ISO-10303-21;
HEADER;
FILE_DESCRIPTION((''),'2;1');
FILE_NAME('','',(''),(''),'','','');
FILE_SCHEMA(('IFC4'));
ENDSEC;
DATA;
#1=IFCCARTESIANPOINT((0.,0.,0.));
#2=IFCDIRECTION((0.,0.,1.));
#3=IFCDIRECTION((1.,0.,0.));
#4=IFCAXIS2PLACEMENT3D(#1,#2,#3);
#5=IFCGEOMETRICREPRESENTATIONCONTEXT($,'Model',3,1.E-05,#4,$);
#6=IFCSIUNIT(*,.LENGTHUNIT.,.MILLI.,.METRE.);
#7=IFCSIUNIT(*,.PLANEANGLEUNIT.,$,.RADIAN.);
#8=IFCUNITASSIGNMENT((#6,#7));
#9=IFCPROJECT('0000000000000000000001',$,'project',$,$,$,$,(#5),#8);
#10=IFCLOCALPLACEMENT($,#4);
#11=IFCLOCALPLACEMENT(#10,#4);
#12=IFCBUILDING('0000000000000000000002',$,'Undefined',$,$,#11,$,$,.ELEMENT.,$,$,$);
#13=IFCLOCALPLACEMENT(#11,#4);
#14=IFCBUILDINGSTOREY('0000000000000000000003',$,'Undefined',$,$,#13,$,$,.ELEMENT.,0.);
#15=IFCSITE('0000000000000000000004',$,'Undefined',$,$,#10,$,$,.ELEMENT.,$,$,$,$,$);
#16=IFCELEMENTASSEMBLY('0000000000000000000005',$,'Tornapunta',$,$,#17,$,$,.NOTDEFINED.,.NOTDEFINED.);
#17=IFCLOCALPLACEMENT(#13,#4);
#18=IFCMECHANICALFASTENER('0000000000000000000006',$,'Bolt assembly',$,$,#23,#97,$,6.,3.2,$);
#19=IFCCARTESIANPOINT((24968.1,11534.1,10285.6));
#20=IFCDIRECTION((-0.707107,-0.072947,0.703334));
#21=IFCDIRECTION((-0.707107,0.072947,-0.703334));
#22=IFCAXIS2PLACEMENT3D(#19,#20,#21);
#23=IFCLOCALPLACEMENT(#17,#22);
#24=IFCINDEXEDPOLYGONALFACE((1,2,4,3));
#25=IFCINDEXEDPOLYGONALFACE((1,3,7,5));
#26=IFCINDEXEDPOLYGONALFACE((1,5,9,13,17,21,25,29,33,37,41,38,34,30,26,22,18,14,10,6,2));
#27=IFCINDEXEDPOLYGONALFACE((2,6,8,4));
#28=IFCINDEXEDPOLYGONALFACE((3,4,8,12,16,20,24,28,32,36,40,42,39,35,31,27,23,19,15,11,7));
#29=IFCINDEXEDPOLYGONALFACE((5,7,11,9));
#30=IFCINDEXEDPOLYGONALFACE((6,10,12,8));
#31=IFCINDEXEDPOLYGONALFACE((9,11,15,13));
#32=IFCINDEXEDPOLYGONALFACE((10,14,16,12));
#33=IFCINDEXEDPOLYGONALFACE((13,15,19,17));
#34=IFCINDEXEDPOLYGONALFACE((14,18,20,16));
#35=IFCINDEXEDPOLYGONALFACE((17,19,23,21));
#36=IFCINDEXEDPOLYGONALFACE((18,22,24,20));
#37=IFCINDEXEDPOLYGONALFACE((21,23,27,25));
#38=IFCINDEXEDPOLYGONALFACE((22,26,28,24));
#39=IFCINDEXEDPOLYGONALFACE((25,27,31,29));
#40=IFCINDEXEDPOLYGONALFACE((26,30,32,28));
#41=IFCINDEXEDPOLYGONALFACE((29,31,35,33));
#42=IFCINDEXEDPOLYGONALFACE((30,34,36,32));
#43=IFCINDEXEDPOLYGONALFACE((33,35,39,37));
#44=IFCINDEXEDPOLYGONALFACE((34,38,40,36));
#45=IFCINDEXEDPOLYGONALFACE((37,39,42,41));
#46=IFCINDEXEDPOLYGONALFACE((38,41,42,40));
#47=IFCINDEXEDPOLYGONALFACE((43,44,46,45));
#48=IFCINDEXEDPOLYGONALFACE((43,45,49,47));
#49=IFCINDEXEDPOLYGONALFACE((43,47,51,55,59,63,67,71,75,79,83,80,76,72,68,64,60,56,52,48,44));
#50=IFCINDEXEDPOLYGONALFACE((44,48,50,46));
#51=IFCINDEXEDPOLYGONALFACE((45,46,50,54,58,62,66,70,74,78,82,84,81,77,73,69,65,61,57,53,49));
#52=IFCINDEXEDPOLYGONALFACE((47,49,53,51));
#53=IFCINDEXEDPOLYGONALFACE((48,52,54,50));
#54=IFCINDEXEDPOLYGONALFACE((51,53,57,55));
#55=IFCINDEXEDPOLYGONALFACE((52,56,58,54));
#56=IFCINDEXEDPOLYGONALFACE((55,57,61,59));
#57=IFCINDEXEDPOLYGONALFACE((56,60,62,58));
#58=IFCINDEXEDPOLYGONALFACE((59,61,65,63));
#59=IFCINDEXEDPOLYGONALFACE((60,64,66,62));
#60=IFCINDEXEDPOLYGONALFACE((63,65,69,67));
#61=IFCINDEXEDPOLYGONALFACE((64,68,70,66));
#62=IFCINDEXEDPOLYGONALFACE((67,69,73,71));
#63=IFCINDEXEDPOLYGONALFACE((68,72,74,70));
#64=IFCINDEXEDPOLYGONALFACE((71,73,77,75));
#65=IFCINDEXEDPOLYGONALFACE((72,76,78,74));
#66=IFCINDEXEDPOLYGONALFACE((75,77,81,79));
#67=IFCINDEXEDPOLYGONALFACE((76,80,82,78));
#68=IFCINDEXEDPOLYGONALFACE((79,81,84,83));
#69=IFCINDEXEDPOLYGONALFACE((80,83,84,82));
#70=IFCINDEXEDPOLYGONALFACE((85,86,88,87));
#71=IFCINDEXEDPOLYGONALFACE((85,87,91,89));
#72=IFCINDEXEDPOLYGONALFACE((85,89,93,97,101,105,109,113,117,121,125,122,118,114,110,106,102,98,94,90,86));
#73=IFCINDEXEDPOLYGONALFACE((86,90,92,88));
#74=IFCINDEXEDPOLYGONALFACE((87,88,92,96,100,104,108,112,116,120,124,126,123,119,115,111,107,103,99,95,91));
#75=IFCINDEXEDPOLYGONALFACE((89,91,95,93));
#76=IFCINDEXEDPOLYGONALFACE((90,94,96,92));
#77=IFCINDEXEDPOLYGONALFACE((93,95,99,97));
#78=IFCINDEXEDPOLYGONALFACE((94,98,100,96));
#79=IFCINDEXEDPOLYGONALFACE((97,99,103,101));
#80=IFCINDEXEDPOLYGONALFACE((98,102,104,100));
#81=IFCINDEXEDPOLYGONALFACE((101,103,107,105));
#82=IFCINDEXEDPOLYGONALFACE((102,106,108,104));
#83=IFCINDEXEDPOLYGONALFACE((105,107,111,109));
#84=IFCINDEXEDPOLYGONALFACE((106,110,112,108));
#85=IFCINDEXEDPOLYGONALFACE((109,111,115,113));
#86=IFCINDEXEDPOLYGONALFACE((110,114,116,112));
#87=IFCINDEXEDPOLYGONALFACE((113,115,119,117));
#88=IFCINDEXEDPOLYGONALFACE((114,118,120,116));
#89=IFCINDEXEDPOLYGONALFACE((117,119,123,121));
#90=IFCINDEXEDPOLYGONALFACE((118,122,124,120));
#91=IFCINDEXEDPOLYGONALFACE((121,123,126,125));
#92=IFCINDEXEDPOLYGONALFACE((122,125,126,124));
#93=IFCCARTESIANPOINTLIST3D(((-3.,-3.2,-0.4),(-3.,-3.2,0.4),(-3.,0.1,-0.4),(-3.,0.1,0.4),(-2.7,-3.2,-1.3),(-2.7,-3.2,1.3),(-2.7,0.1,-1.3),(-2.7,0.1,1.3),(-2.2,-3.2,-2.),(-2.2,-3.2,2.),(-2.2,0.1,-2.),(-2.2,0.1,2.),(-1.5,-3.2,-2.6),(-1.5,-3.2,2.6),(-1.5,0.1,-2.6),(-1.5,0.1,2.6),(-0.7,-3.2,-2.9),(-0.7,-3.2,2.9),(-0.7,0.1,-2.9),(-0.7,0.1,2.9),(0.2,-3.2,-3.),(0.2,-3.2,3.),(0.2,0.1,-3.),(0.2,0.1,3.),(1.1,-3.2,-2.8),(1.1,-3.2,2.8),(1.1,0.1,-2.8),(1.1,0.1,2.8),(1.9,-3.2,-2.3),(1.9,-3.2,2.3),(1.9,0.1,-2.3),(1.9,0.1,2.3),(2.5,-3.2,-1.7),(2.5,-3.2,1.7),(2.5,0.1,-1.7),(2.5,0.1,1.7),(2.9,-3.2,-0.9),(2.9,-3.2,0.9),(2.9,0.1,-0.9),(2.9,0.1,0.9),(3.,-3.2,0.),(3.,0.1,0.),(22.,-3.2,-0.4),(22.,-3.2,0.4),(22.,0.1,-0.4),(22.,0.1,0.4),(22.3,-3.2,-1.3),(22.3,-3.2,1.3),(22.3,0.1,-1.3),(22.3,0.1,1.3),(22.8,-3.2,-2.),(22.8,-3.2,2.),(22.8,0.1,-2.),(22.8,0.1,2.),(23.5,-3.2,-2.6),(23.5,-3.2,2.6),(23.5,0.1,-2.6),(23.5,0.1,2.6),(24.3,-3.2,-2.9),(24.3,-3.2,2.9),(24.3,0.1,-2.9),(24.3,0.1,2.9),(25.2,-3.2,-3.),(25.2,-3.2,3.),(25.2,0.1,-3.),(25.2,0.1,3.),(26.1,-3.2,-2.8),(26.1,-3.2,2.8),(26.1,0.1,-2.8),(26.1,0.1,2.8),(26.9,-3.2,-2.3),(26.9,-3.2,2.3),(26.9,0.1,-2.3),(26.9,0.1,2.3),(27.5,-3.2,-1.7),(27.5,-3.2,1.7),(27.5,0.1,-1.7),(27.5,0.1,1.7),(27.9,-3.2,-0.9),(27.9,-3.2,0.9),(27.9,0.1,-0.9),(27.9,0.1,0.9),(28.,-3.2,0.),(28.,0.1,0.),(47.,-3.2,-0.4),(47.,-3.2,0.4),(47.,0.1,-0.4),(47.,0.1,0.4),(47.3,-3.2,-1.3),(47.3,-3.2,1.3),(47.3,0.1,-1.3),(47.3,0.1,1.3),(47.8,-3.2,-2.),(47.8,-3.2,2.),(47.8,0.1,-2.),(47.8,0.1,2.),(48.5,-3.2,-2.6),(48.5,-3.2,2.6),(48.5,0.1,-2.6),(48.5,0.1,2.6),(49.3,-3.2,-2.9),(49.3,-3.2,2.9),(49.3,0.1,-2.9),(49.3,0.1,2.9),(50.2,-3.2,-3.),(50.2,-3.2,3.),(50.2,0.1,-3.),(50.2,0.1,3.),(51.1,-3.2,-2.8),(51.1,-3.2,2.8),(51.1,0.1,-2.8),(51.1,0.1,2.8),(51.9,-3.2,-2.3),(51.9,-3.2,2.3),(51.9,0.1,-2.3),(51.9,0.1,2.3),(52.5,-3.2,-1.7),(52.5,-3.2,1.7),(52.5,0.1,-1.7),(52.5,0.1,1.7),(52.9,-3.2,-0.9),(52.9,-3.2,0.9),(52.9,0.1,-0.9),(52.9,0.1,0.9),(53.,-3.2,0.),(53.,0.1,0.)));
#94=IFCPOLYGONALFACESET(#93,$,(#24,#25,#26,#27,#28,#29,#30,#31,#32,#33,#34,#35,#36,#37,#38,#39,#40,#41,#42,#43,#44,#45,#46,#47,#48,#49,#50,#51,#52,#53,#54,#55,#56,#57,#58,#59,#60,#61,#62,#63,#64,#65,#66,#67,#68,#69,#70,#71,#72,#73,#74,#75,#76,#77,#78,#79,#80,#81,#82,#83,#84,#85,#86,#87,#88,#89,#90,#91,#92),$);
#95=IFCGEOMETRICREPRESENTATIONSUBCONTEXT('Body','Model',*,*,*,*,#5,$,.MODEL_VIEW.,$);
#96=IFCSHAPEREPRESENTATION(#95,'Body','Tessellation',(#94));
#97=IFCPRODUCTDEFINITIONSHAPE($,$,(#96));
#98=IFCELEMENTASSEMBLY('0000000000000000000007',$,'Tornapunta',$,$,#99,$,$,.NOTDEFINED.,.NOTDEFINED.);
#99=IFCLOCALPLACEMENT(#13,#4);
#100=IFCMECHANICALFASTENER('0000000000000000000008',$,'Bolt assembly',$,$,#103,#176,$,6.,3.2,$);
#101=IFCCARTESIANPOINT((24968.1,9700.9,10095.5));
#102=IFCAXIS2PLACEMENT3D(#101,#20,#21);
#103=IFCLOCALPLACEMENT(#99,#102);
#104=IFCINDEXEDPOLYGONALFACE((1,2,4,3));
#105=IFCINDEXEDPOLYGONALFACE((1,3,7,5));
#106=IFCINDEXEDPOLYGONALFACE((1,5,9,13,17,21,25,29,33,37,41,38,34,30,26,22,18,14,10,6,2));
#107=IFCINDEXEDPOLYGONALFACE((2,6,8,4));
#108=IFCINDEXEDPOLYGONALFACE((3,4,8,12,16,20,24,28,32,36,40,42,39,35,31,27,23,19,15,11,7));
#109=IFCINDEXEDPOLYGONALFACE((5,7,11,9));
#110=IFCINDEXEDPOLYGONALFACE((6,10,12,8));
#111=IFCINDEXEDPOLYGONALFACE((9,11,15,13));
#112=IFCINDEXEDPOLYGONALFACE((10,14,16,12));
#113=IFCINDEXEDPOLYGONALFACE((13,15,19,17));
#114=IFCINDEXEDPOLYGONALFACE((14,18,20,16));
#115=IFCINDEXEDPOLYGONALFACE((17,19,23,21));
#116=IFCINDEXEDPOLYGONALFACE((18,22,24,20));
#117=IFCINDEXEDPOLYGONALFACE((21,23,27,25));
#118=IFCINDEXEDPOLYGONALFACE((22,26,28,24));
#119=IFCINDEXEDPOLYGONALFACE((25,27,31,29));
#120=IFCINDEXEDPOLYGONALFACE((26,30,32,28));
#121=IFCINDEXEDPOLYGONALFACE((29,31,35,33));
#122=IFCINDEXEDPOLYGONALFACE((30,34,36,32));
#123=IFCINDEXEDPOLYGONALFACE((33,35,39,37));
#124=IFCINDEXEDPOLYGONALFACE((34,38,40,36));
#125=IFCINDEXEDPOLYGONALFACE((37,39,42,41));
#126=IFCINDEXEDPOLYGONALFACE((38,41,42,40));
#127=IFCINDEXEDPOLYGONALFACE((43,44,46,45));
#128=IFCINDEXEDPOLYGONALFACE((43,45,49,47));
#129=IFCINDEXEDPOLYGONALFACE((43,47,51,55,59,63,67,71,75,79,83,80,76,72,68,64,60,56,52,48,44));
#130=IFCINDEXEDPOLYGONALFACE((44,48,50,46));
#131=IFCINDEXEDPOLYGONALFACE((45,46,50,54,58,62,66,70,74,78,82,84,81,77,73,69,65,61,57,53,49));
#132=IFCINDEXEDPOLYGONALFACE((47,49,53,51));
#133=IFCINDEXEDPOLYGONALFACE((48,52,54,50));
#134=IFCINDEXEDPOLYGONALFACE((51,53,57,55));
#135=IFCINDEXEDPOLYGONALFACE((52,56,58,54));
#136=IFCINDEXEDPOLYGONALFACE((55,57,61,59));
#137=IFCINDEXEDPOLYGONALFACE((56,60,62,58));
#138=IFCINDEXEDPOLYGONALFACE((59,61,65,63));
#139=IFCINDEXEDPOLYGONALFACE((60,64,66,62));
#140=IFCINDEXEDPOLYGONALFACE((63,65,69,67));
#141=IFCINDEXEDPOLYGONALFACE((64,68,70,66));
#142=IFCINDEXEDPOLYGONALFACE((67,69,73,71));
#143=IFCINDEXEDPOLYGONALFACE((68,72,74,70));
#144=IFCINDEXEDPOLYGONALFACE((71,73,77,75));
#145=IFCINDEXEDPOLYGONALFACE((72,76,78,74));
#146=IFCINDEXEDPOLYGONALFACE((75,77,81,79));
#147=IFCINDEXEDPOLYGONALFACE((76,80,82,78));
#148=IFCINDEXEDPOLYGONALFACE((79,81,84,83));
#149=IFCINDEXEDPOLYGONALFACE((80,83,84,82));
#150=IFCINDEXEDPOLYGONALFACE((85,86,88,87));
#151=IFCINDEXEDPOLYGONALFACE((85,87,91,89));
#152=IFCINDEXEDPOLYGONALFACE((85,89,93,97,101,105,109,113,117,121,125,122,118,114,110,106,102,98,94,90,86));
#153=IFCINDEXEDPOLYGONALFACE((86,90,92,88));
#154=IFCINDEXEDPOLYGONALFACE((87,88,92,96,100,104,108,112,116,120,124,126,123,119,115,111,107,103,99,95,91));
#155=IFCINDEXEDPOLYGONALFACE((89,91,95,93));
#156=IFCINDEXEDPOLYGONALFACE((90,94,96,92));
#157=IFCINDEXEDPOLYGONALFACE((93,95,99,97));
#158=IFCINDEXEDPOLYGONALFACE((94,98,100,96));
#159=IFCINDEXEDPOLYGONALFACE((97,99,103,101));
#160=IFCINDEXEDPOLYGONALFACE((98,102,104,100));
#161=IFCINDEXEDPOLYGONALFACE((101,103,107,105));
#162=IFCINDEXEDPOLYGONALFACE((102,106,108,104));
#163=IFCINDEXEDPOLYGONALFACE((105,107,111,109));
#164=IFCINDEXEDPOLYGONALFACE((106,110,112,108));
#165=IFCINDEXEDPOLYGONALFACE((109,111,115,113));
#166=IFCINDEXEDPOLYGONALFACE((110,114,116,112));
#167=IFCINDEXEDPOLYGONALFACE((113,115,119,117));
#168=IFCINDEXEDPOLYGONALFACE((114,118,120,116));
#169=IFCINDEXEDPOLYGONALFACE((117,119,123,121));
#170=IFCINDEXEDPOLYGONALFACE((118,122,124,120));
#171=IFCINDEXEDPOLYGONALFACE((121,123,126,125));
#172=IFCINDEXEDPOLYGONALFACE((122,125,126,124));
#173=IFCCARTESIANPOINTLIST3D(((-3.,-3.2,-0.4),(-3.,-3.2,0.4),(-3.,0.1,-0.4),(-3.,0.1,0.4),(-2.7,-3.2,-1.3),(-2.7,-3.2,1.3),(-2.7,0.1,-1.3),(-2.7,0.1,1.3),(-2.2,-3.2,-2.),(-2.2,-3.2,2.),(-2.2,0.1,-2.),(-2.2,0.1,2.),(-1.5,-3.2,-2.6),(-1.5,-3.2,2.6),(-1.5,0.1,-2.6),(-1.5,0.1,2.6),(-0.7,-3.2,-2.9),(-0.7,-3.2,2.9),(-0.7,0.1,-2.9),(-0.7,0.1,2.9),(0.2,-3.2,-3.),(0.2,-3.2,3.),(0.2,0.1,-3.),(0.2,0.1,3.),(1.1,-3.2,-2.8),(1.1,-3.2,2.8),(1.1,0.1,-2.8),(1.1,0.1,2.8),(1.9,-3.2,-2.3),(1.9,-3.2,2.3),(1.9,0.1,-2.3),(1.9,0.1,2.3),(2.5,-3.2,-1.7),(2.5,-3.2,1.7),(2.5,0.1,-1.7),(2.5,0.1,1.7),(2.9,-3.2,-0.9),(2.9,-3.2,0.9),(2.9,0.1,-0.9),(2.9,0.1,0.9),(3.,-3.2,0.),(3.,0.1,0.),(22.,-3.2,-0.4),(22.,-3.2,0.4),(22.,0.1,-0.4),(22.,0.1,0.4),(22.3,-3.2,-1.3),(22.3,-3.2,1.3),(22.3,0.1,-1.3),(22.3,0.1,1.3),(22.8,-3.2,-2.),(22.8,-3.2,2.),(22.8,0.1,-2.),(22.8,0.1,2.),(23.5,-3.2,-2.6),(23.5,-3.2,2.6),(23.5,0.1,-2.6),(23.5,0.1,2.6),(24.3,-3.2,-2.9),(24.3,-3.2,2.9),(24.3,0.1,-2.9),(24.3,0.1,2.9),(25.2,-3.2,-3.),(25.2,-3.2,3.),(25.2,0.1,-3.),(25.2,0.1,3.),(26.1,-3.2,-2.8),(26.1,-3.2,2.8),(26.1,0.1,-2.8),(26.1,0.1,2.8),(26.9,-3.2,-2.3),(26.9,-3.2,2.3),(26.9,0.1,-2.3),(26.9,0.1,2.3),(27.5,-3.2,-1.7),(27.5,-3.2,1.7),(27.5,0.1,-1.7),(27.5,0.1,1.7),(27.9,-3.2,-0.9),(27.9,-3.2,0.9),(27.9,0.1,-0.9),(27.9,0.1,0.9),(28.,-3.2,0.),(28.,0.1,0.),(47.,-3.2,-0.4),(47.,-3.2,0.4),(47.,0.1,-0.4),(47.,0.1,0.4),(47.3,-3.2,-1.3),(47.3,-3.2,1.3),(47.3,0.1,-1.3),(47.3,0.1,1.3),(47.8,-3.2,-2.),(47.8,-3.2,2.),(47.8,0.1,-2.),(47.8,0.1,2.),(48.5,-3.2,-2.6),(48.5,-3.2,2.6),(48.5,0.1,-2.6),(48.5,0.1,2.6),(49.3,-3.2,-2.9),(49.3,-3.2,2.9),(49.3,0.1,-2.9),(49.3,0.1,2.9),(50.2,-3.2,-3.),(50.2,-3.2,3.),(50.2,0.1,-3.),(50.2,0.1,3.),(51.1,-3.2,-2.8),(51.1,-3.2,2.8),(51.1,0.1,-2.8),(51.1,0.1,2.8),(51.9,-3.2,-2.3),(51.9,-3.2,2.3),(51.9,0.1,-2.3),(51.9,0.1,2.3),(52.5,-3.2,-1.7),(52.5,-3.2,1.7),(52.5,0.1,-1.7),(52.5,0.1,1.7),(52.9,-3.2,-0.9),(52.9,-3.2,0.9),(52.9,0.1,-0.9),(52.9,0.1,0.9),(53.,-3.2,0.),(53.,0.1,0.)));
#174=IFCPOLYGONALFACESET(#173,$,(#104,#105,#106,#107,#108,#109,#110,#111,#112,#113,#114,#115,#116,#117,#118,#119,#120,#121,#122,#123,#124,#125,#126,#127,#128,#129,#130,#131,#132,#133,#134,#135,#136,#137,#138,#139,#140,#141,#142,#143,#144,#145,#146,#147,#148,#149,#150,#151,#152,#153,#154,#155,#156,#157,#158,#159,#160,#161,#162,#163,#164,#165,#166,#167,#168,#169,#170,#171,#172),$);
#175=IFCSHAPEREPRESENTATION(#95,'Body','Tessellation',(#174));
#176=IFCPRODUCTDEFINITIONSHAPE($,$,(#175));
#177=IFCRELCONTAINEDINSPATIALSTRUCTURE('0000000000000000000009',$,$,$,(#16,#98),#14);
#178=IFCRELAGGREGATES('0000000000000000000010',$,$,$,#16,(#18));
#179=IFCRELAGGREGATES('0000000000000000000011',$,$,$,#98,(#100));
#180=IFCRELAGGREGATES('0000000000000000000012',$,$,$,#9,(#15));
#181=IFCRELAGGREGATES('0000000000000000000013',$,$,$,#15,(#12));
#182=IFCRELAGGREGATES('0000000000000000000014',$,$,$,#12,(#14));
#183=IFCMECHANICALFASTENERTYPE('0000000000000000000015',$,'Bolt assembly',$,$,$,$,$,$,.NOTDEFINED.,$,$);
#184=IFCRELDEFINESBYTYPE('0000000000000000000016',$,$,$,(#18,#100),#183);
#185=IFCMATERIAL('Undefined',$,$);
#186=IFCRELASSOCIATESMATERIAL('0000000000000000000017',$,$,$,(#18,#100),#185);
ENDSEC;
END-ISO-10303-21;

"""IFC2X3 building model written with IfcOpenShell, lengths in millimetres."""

from ifc_helpers import new_model, si_unit, frame, origin_with_axes, origin_2d_with_axis, place, context, subcontext, project, spatial, circle, extrude, source, transform, mapped, material, type_object, element, aggregate, save


model = new_model("IFC2X3")

# Units and contexts
model_context = context("Model", 3, precision=1e-05, world=origin_with_axes())
body_context = subcontext(model_context, "Body", "Model", "MODEL_VIEW")
ifc_project = project(units=[si_unit("LENGTHUNIT", "METRE", prefix="MILLI"), si_unit("PLANEANGLEUNIT", "RADIAN")], contexts=[model_context])

# Site, building, storey
site_placement = place(None, origin_with_axes())
site = spatial("IfcSite", under=ifc_project, at=site_placement, Name="Undefined", CompositionType="ELEMENT")
building_placement = place(site_placement, origin_with_axes())
building = spatial("IfcBuilding", under=site, at=building_placement, Name="Undefined", CompositionType="ELEMENT")
storey_placement = place(building_placement, origin_with_axes())
storey = spatial("IfcBuildingStorey", under=building, at=storey_placement, Name="Undefined", CompositionType="ELEMENT", Elevation=0.0)

# Shared definitions
ifc_material_1 = material(Name="Undefined")
mechanical_fastener_type = type_object("IfcMechanicalFastenerType", Name="Bolt assembly")
shared_shape_1 = source(origin_with_axes(), body_context, "Body", "SweptSolid", [
    extrude(circle(Radius=3.0, at=origin_2d_with_axis()), frame((0.0, -3.2, 0.0), z_axis=(0.0, 1.0, 0.0), x_axis=(1.0, 0.0, 0.0)), (0.0, 0.0, 1.0), 3.3),
])

# Element assemblies, mechanical fasteners
assembly_1_placement = place(storey_placement, origin_with_axes())
assembly_1 = element("IfcElementAssembly", 1, at=assembly_1_placement, inside=storey, Name="Tornapunta", AssemblyPlace="NOTDEFINED", PredefinedType="NOTDEFINED")
mechanical_fastener_1_placement = place(assembly_1_placement, frame((24968.1, 11534.1, 10285.6), z_axis=(-0.707107, -0.072947, 0.703334), x_axis=(-0.707107, 0.072947, -0.703334)))
mechanical_fastener_1 = element("IfcMechanicalFastener", 2, at=mechanical_fastener_1_placement, type_object=mechanical_fastener_type, material=ifc_material_1, Name="Bolt assembly", NominalDiameter=6.0, NominalLength=3.2, context=body_context, shape_type="MappedRepresentation", body=[
    mapped(shared_shape_1, transform((0.0, 0.0, 0.0))),
    mapped(shared_shape_1, transform((25.0, 0.0, 0.0))),
    mapped(shared_shape_1, transform((50.0, 0.0, 0.0))),
])
aggregate(assembly_1, [mechanical_fastener_1])
assembly_2_placement = place(storey_placement, origin_with_axes())
assembly_2 = element("IfcElementAssembly", 3, at=assembly_2_placement, inside=storey, Name="Tornapunta", AssemblyPlace="NOTDEFINED", PredefinedType="NOTDEFINED")
mechanical_fastener_2_placement = place(assembly_2_placement, frame((24968.1, 9700.9, 10095.5), z_axis=(-0.707107, -0.072947, 0.703334), x_axis=(-0.707107, 0.072947, -0.703334)))
mechanical_fastener_2 = element("IfcMechanicalFastener", 4, at=mechanical_fastener_2_placement, type_object=mechanical_fastener_type, material=ifc_material_1, Name="Bolt assembly", NominalDiameter=6.0, NominalLength=3.2, context=body_context, shape_type="MappedRepresentation", body=[
    mapped(shared_shape_1, transform((0.0, 0.0, 0.0))),
    mapped(shared_shape_1, transform((25.0, 0.0, 0.0))),
    mapped(shared_shape_1, transform((50.0, 0.0, 0.0))),
])

aggregate(assembly_2, [mechanical_fastener_2])

save(model, "model.ifc")
